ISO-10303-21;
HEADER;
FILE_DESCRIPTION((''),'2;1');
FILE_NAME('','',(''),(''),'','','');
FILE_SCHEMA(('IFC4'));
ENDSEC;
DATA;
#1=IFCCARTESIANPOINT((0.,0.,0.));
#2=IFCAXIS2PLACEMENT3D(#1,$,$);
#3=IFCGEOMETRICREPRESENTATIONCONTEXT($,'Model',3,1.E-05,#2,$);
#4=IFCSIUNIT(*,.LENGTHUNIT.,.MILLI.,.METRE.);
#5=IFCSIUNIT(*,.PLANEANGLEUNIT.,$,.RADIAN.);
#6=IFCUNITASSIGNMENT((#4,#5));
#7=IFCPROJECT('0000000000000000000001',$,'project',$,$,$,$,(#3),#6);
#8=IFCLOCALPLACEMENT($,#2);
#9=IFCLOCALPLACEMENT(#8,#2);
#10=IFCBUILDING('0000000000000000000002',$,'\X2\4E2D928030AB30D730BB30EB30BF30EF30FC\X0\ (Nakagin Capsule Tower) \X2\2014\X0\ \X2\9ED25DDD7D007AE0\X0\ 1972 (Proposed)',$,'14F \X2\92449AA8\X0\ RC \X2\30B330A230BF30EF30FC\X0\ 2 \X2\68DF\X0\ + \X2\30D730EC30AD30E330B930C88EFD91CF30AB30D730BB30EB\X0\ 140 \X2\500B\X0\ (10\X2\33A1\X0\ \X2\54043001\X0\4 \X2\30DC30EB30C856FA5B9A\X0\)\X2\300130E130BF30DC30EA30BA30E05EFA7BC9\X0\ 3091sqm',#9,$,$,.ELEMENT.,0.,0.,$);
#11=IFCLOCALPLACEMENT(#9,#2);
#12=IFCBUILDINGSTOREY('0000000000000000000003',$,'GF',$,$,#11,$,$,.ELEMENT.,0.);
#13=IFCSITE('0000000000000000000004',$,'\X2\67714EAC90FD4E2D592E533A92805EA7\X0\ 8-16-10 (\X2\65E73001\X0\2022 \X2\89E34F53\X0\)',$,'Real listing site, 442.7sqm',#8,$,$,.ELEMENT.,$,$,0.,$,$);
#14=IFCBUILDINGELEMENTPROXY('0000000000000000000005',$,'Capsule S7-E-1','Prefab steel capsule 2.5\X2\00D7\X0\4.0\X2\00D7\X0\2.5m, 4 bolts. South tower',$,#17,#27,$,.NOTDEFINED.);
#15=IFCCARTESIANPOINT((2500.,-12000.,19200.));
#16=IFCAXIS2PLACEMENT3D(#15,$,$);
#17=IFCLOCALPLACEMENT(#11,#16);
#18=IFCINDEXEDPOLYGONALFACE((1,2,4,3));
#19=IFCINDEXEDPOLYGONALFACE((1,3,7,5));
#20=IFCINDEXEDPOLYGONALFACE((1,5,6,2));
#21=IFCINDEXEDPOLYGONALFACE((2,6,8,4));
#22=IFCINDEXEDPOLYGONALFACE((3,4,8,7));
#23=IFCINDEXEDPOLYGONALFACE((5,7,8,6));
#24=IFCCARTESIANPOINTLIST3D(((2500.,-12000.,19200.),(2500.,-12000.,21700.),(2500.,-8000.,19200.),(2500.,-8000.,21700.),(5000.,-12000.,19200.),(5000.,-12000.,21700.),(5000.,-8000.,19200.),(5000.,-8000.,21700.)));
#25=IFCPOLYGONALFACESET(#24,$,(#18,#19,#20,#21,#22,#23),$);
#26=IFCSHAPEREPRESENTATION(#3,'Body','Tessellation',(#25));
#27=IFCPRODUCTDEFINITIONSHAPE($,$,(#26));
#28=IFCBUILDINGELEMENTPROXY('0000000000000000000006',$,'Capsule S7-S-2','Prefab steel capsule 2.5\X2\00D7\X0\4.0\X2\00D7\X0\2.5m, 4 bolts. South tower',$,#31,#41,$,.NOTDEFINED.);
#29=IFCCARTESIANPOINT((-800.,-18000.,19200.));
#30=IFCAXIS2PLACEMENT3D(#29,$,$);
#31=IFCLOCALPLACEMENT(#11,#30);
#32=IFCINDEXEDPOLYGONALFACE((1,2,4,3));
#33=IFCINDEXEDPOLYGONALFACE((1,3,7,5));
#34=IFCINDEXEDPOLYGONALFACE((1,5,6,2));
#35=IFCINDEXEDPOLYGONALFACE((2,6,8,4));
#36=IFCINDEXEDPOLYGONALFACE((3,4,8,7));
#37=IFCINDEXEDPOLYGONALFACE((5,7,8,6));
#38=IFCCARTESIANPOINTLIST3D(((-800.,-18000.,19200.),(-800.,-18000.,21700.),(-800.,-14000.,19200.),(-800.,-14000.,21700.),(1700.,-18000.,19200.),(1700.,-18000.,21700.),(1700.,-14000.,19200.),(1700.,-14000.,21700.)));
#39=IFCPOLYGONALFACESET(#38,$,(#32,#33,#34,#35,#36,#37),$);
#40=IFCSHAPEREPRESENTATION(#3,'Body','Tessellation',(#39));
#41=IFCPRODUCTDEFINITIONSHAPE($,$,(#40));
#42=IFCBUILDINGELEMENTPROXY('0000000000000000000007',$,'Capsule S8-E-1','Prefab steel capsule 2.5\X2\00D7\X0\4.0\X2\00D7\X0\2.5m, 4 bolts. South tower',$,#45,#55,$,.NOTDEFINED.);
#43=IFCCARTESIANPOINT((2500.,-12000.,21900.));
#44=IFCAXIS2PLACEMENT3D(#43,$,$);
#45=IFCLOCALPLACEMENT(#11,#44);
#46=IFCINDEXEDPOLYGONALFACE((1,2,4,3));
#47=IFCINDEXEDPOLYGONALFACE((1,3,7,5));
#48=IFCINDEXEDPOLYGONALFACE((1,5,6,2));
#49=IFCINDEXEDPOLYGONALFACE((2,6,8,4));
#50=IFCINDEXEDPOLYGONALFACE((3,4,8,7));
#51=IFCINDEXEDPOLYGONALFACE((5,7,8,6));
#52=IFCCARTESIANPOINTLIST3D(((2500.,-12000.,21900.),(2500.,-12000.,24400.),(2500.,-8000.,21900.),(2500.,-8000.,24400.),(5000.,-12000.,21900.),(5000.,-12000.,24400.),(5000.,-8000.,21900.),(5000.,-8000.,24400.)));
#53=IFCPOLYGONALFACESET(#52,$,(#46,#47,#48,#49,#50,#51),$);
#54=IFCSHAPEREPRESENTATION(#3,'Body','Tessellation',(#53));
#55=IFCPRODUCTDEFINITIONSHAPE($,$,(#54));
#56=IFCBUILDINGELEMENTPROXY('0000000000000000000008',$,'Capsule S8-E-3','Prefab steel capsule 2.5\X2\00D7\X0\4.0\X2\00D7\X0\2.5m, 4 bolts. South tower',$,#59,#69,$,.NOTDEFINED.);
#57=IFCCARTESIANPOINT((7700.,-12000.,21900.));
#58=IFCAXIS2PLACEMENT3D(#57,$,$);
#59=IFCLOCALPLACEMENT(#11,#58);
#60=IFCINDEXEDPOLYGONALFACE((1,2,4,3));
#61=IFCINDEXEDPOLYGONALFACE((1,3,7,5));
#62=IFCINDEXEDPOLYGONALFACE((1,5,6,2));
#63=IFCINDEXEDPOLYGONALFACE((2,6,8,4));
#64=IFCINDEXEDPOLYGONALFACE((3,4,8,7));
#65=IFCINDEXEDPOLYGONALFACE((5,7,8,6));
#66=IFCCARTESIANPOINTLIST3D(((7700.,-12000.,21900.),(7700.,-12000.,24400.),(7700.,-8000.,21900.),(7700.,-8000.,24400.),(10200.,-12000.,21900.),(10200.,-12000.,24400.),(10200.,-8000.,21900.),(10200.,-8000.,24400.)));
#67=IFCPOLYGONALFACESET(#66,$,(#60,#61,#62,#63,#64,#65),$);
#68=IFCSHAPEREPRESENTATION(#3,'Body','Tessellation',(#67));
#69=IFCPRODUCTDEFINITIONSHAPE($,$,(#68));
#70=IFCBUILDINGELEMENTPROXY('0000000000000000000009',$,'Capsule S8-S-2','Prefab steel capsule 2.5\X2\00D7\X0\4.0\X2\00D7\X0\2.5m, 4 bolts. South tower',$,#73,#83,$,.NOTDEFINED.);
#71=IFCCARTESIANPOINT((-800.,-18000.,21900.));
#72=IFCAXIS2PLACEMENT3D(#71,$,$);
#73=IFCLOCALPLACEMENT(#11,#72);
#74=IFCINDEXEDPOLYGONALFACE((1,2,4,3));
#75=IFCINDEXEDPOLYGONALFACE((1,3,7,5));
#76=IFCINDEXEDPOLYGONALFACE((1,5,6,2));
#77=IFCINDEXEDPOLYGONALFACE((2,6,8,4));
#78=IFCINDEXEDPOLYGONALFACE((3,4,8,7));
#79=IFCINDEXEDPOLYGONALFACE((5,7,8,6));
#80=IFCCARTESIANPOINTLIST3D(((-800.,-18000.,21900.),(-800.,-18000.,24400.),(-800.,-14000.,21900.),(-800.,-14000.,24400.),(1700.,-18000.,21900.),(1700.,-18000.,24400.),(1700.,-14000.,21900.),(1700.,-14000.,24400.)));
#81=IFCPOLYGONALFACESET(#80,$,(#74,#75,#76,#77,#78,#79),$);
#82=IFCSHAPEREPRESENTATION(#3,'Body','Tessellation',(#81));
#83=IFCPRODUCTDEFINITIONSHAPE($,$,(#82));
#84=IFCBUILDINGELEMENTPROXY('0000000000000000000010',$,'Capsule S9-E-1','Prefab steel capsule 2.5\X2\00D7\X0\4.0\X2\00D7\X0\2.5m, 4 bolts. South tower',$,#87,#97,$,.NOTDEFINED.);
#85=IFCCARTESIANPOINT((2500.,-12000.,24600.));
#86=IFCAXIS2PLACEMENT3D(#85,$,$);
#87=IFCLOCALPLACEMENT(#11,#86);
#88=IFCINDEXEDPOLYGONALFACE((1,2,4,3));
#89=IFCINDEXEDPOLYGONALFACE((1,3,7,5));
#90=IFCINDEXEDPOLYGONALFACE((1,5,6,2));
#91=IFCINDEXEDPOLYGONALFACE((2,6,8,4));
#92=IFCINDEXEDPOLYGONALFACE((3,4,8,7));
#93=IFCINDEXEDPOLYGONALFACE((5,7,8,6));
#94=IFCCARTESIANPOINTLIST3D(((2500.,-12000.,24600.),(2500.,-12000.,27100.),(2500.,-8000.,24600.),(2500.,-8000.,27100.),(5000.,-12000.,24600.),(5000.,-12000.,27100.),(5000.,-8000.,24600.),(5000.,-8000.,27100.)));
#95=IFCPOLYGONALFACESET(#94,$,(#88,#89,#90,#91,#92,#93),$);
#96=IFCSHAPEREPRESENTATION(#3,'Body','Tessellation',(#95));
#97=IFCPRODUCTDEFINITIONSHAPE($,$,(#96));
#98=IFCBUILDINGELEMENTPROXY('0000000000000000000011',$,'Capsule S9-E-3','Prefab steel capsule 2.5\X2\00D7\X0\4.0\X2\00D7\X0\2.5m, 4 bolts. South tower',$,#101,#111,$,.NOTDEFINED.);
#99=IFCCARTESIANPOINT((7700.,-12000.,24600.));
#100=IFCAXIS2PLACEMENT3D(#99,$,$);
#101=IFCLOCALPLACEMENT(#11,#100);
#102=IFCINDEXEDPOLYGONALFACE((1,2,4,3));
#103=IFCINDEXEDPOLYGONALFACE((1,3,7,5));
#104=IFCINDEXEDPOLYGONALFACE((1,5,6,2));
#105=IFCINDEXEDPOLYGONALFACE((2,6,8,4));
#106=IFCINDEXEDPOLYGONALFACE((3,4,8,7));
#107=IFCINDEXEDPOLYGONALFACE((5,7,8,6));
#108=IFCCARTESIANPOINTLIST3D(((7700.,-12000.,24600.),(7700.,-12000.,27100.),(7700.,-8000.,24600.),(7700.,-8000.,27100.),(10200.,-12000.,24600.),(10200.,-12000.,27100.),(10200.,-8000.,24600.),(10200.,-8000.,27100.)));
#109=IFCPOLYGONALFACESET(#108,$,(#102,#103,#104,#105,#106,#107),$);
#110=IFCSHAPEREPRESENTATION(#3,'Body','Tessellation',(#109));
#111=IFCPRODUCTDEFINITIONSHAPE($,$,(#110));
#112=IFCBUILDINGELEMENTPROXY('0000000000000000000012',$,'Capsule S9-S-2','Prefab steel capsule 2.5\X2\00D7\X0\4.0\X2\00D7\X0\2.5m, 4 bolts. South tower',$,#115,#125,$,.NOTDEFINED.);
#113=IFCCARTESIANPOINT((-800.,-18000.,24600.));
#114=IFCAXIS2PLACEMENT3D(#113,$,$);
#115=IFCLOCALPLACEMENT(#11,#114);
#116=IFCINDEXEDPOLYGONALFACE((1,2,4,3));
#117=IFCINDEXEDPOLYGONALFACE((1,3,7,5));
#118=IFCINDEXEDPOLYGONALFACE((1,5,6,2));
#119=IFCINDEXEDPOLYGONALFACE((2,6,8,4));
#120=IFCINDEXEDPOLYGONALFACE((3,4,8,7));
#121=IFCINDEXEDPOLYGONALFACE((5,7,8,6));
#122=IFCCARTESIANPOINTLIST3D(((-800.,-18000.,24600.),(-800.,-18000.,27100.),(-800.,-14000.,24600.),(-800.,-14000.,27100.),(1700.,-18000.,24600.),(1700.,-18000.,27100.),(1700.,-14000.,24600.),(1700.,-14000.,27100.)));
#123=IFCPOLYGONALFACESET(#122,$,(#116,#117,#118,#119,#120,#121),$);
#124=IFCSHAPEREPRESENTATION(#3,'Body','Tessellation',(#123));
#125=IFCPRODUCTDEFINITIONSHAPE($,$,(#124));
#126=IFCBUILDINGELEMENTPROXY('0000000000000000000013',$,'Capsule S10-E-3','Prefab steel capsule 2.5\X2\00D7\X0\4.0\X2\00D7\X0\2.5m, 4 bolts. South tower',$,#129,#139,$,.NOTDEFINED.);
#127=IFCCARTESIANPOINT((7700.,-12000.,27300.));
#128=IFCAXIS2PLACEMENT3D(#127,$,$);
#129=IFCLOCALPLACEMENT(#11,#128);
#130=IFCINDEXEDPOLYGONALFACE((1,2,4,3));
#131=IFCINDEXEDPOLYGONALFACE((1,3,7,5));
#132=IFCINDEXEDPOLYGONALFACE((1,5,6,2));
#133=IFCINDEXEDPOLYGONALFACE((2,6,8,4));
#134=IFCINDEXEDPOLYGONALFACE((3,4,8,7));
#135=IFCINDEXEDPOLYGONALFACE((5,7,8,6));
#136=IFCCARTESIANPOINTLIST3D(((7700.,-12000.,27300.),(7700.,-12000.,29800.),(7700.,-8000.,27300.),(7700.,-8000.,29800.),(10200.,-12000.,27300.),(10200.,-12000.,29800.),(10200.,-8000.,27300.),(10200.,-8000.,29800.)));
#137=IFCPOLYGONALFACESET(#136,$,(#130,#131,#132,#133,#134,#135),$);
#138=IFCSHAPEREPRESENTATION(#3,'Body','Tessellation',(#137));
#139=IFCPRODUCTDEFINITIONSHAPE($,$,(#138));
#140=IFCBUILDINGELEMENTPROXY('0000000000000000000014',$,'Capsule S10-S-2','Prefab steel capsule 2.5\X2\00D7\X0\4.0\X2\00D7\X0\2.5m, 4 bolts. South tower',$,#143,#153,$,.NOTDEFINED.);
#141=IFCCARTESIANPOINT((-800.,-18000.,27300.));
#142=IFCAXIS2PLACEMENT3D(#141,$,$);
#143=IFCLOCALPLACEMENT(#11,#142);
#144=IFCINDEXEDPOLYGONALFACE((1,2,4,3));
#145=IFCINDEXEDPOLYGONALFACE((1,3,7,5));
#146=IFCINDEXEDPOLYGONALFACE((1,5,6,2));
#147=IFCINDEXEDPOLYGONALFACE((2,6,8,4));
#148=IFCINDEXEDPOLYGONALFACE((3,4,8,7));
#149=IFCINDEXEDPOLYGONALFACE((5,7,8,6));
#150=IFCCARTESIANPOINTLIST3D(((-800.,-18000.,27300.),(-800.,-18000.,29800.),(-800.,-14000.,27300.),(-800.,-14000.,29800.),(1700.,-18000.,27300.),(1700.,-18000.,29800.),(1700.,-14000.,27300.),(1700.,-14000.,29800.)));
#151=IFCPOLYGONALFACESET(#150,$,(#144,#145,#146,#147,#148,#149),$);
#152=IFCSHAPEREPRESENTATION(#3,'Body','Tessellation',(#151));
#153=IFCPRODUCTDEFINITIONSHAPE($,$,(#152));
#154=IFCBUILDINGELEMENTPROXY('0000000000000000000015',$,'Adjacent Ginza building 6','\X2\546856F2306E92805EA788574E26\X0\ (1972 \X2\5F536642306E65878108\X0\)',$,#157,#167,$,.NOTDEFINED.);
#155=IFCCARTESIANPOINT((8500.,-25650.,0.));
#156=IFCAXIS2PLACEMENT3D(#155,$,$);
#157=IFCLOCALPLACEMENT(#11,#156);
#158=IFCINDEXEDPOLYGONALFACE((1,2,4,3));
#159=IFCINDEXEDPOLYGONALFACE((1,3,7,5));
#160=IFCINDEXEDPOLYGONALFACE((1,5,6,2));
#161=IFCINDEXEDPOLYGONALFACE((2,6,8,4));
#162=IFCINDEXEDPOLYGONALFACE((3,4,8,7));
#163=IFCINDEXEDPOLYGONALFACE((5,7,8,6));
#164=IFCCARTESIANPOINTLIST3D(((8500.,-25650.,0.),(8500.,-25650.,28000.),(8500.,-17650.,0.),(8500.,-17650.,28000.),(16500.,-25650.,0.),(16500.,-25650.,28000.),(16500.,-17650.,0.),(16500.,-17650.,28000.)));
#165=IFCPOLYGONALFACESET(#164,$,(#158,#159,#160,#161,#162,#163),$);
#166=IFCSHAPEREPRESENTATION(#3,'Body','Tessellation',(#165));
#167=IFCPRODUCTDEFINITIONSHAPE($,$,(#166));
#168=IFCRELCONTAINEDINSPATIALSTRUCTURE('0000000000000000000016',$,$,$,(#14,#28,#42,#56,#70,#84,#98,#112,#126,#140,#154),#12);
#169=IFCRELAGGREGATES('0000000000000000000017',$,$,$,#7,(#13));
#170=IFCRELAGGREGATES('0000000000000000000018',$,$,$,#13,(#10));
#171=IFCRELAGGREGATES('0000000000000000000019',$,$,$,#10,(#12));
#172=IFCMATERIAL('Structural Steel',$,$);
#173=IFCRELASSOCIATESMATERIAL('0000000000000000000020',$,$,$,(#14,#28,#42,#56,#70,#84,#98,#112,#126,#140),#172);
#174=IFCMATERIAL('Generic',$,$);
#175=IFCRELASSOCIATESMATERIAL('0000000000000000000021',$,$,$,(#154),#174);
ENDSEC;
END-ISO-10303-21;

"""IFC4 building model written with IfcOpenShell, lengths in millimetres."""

from ifc_helpers import new_model, si_unit, frame, frame_2d, origin, place, context, project, spatial, rectangle, extrude, material, element, save


model = new_model("IFC4")

# Units and contexts
model_context = context("Model", 3, precision=1e-05, world=origin())
ifc_project = project(units=[si_unit("LENGTHUNIT", "METRE", prefix="MILLI"), si_unit("PLANEANGLEUNIT", "RADIAN")], contexts=[model_context])

# Site, building, storey
site_placement = place(None, origin())
site = spatial("IfcSite", under=ifc_project, at=site_placement, Name="東京都中央区銀座 8-16-10 (旧、2022 解体)", ObjectType="Real listing site, 442.7sqm", CompositionType="ELEMENT", RefElevation=0.0)
building_placement = place(site_placement, origin())
building = spatial("IfcBuilding", under=site, at=building_placement, Name="中銀カプセルタワー (Nakagin Capsule Tower) — 黒川紀章 1972 (Proposed)", ObjectType="14F 鉄骨 RC コアタワー 2 棟 + プレキャスト軽量カプセル 140 個 (10㎡ 各、4 ボルト固定)、メタボリズム建築 3091sqm", CompositionType="ELEMENT", ElevationOfRefHeight=0.0, ElevationOfTerrain=0.0)
storey_placement = place(building_placement, origin())
storey = spatial("IfcBuildingStorey", under=building, at=storey_placement, Name="GF", CompositionType="ELEMENT", Elevation=0.0)

# Shared definitions
ifc_material_1 = material(Name="Structural Steel")

# Building element proxies
proxy_1_placement = place(storey_placement, frame((2500.0, -12000.0, 19200.0)))
element("IfcBuildingElementProxy", 1, at=proxy_1_placement, inside=storey, material=ifc_material_1, Name="Capsule S7-E-1", Description="Prefab steel capsule 2.5×4.0×2.5m, 4 bolts. South tower", PredefinedType="NOTDEFINED", context=model_context, shape_type="SweptSolid", body=[
    extrude(rectangle(XDim=2500.0, YDim=4000.0, at=frame_2d((1250.0, 2000.0))), frame((2500.0, -12000.0, 19200.0)), (0.0, 0.0, 1.0), 2500.0),
])
proxy_2_placement = place(storey_placement, frame((-800.0, -18000.0, 19200.0)))
element("IfcBuildingElementProxy", 2, at=proxy_2_placement, inside=storey, material=ifc_material_1, Name="Capsule S7-S-2", Description="Prefab steel capsule 2.5×4.0×2.5m, 4 bolts. South tower", PredefinedType="NOTDEFINED", context=model_context, shape_type="SweptSolid", body=[
    extrude(rectangle(XDim=2500.0, YDim=4000.0, at=frame_2d((1250.0, 2000.0))), frame((-800.0, -18000.0, 19200.0)), (0.0, 0.0, 1.0), 2500.0),
])
proxy_3_placement = place(storey_placement, frame((2500.0, -12000.0, 21900.0)))
element("IfcBuildingElementProxy", 3, at=proxy_3_placement, inside=storey, material=ifc_material_1, Name="Capsule S8-E-1", Description="Prefab steel capsule 2.5×4.0×2.5m, 4 bolts. South tower", PredefinedType="NOTDEFINED", context=model_context, shape_type="SweptSolid", body=[
    extrude(rectangle(XDim=2500.0, YDim=4000.0, at=frame_2d((1250.0, 2000.0))), frame((2500.0, -12000.0, 21900.0)), (0.0, 0.0, 1.0), 2500.0),
])
proxy_4_placement = place(storey_placement, frame((7700.0, -12000.0, 21900.0)))
element("IfcBuildingElementProxy", 4, at=proxy_4_placement, inside=storey, material=ifc_material_1, Name="Capsule S8-E-3", Description="Prefab steel capsule 2.5×4.0×2.5m, 4 bolts. South tower", PredefinedType="NOTDEFINED", context=model_context, shape_type="SweptSolid", body=[
    extrude(rectangle(XDim=2500.0, YDim=4000.0, at=frame_2d((1250.0, 2000.0))), frame((7700.0, -12000.0, 21900.0)), (0.0, 0.0, 1.0), 2500.0),
])
proxy_5_placement = place(storey_placement, frame((-800.0, -18000.0, 21900.0)))
element("IfcBuildingElementProxy", 5, at=proxy_5_placement, inside=storey, material=ifc_material_1, Name="Capsule S8-S-2", Description="Prefab steel capsule 2.5×4.0×2.5m, 4 bolts. South tower", PredefinedType="NOTDEFINED", context=model_context, shape_type="SweptSolid", body=[
    extrude(rectangle(XDim=2500.0, YDim=4000.0, at=frame_2d((1250.0, 2000.0))), frame((-800.0, -18000.0, 21900.0)), (0.0, 0.0, 1.0), 2500.0),
])
proxy_6_placement = place(storey_placement, frame((2500.0, -12000.0, 24600.0)))
element("IfcBuildingElementProxy", 6, at=proxy_6_placement, inside=storey, material=ifc_material_1, Name="Capsule S9-E-1", Description="Prefab steel capsule 2.5×4.0×2.5m, 4 bolts. South tower", PredefinedType="NOTDEFINED", context=model_context, shape_type="SweptSolid", body=[
    extrude(rectangle(XDim=2500.0, YDim=4000.0, at=frame_2d((1250.0, 2000.0))), frame((2500.0, -12000.0, 24600.0)), (0.0, 0.0, 1.0), 2500.0),
])
proxy_7_placement = place(storey_placement, frame((7700.0, -12000.0, 24600.0)))
element("IfcBuildingElementProxy", 7, at=proxy_7_placement, inside=storey, material=ifc_material_1, Name="Capsule S9-E-3", Description="Prefab steel capsule 2.5×4.0×2.5m, 4 bolts. South tower", PredefinedType="NOTDEFINED", context=model_context, shape_type="SweptSolid", body=[
    extrude(rectangle(XDim=2500.0, YDim=4000.0, at=frame_2d((1250.0, 2000.0))), frame((7700.0, -12000.0, 24600.0)), (0.0, 0.0, 1.0), 2500.0),
])
proxy_8_placement = place(storey_placement, frame((-800.0, -18000.0, 24600.0)))
element("IfcBuildingElementProxy", 8, at=proxy_8_placement, inside=storey, material=ifc_material_1, Name="Capsule S9-S-2", Description="Prefab steel capsule 2.5×4.0×2.5m, 4 bolts. South tower", PredefinedType="NOTDEFINED", context=model_context, shape_type="SweptSolid", body=[
    extrude(rectangle(XDim=2500.0, YDim=4000.0, at=frame_2d((1250.0, 2000.0))), frame((-800.0, -18000.0, 24600.0)), (0.0, 0.0, 1.0), 2500.0),
])
proxy_9_placement = place(storey_placement, frame((7700.0, -12000.0, 27300.0)))
element("IfcBuildingElementProxy", 9, at=proxy_9_placement, inside=storey, material=ifc_material_1, Name="Capsule S10-E-3", Description="Prefab steel capsule 2.5×4.0×2.5m, 4 bolts. South tower", PredefinedType="NOTDEFINED", context=model_context, shape_type="SweptSolid", body=[
    extrude(rectangle(XDim=2500.0, YDim=4000.0, at=frame_2d((1250.0, 2000.0))), frame((7700.0, -12000.0, 27300.0)), (0.0, 0.0, 1.0), 2500.0),
])
proxy_10_placement = place(storey_placement, frame((-800.0, -18000.0, 27300.0)))
element("IfcBuildingElementProxy", 10, at=proxy_10_placement, inside=storey, material=ifc_material_1, Name="Capsule S10-S-2", Description="Prefab steel capsule 2.5×4.0×2.5m, 4 bolts. South tower", PredefinedType="NOTDEFINED", context=model_context, shape_type="SweptSolid", body=[
    extrude(rectangle(XDim=2500.0, YDim=4000.0, at=frame_2d((1250.0, 2000.0))), frame((-800.0, -18000.0, 27300.0)), (0.0, 0.0, 1.0), 2500.0),
])
ifc_material_2 = material(Name="Generic")
proxy_11_placement = place(storey_placement, frame((8500.0, -25650.0, 0.0)))
element("IfcBuildingElementProxy", 11, at=proxy_11_placement, inside=storey, material=ifc_material_2, Name="Adjacent Ginza building 6", Description="周囲の銀座街並 (1972 当時の文脈)", PredefinedType="NOTDEFINED", context=model_context, shape_type="SweptSolid", body=[
    extrude(rectangle(XDim=8000.0, YDim=8000.0, at=frame_2d((4000.0, 4000.0))), frame((8500.0, -25650.0, 0.0)), (0.0, 0.0, 1.0), 28000.0),
])

save(model, "model.ifc")
